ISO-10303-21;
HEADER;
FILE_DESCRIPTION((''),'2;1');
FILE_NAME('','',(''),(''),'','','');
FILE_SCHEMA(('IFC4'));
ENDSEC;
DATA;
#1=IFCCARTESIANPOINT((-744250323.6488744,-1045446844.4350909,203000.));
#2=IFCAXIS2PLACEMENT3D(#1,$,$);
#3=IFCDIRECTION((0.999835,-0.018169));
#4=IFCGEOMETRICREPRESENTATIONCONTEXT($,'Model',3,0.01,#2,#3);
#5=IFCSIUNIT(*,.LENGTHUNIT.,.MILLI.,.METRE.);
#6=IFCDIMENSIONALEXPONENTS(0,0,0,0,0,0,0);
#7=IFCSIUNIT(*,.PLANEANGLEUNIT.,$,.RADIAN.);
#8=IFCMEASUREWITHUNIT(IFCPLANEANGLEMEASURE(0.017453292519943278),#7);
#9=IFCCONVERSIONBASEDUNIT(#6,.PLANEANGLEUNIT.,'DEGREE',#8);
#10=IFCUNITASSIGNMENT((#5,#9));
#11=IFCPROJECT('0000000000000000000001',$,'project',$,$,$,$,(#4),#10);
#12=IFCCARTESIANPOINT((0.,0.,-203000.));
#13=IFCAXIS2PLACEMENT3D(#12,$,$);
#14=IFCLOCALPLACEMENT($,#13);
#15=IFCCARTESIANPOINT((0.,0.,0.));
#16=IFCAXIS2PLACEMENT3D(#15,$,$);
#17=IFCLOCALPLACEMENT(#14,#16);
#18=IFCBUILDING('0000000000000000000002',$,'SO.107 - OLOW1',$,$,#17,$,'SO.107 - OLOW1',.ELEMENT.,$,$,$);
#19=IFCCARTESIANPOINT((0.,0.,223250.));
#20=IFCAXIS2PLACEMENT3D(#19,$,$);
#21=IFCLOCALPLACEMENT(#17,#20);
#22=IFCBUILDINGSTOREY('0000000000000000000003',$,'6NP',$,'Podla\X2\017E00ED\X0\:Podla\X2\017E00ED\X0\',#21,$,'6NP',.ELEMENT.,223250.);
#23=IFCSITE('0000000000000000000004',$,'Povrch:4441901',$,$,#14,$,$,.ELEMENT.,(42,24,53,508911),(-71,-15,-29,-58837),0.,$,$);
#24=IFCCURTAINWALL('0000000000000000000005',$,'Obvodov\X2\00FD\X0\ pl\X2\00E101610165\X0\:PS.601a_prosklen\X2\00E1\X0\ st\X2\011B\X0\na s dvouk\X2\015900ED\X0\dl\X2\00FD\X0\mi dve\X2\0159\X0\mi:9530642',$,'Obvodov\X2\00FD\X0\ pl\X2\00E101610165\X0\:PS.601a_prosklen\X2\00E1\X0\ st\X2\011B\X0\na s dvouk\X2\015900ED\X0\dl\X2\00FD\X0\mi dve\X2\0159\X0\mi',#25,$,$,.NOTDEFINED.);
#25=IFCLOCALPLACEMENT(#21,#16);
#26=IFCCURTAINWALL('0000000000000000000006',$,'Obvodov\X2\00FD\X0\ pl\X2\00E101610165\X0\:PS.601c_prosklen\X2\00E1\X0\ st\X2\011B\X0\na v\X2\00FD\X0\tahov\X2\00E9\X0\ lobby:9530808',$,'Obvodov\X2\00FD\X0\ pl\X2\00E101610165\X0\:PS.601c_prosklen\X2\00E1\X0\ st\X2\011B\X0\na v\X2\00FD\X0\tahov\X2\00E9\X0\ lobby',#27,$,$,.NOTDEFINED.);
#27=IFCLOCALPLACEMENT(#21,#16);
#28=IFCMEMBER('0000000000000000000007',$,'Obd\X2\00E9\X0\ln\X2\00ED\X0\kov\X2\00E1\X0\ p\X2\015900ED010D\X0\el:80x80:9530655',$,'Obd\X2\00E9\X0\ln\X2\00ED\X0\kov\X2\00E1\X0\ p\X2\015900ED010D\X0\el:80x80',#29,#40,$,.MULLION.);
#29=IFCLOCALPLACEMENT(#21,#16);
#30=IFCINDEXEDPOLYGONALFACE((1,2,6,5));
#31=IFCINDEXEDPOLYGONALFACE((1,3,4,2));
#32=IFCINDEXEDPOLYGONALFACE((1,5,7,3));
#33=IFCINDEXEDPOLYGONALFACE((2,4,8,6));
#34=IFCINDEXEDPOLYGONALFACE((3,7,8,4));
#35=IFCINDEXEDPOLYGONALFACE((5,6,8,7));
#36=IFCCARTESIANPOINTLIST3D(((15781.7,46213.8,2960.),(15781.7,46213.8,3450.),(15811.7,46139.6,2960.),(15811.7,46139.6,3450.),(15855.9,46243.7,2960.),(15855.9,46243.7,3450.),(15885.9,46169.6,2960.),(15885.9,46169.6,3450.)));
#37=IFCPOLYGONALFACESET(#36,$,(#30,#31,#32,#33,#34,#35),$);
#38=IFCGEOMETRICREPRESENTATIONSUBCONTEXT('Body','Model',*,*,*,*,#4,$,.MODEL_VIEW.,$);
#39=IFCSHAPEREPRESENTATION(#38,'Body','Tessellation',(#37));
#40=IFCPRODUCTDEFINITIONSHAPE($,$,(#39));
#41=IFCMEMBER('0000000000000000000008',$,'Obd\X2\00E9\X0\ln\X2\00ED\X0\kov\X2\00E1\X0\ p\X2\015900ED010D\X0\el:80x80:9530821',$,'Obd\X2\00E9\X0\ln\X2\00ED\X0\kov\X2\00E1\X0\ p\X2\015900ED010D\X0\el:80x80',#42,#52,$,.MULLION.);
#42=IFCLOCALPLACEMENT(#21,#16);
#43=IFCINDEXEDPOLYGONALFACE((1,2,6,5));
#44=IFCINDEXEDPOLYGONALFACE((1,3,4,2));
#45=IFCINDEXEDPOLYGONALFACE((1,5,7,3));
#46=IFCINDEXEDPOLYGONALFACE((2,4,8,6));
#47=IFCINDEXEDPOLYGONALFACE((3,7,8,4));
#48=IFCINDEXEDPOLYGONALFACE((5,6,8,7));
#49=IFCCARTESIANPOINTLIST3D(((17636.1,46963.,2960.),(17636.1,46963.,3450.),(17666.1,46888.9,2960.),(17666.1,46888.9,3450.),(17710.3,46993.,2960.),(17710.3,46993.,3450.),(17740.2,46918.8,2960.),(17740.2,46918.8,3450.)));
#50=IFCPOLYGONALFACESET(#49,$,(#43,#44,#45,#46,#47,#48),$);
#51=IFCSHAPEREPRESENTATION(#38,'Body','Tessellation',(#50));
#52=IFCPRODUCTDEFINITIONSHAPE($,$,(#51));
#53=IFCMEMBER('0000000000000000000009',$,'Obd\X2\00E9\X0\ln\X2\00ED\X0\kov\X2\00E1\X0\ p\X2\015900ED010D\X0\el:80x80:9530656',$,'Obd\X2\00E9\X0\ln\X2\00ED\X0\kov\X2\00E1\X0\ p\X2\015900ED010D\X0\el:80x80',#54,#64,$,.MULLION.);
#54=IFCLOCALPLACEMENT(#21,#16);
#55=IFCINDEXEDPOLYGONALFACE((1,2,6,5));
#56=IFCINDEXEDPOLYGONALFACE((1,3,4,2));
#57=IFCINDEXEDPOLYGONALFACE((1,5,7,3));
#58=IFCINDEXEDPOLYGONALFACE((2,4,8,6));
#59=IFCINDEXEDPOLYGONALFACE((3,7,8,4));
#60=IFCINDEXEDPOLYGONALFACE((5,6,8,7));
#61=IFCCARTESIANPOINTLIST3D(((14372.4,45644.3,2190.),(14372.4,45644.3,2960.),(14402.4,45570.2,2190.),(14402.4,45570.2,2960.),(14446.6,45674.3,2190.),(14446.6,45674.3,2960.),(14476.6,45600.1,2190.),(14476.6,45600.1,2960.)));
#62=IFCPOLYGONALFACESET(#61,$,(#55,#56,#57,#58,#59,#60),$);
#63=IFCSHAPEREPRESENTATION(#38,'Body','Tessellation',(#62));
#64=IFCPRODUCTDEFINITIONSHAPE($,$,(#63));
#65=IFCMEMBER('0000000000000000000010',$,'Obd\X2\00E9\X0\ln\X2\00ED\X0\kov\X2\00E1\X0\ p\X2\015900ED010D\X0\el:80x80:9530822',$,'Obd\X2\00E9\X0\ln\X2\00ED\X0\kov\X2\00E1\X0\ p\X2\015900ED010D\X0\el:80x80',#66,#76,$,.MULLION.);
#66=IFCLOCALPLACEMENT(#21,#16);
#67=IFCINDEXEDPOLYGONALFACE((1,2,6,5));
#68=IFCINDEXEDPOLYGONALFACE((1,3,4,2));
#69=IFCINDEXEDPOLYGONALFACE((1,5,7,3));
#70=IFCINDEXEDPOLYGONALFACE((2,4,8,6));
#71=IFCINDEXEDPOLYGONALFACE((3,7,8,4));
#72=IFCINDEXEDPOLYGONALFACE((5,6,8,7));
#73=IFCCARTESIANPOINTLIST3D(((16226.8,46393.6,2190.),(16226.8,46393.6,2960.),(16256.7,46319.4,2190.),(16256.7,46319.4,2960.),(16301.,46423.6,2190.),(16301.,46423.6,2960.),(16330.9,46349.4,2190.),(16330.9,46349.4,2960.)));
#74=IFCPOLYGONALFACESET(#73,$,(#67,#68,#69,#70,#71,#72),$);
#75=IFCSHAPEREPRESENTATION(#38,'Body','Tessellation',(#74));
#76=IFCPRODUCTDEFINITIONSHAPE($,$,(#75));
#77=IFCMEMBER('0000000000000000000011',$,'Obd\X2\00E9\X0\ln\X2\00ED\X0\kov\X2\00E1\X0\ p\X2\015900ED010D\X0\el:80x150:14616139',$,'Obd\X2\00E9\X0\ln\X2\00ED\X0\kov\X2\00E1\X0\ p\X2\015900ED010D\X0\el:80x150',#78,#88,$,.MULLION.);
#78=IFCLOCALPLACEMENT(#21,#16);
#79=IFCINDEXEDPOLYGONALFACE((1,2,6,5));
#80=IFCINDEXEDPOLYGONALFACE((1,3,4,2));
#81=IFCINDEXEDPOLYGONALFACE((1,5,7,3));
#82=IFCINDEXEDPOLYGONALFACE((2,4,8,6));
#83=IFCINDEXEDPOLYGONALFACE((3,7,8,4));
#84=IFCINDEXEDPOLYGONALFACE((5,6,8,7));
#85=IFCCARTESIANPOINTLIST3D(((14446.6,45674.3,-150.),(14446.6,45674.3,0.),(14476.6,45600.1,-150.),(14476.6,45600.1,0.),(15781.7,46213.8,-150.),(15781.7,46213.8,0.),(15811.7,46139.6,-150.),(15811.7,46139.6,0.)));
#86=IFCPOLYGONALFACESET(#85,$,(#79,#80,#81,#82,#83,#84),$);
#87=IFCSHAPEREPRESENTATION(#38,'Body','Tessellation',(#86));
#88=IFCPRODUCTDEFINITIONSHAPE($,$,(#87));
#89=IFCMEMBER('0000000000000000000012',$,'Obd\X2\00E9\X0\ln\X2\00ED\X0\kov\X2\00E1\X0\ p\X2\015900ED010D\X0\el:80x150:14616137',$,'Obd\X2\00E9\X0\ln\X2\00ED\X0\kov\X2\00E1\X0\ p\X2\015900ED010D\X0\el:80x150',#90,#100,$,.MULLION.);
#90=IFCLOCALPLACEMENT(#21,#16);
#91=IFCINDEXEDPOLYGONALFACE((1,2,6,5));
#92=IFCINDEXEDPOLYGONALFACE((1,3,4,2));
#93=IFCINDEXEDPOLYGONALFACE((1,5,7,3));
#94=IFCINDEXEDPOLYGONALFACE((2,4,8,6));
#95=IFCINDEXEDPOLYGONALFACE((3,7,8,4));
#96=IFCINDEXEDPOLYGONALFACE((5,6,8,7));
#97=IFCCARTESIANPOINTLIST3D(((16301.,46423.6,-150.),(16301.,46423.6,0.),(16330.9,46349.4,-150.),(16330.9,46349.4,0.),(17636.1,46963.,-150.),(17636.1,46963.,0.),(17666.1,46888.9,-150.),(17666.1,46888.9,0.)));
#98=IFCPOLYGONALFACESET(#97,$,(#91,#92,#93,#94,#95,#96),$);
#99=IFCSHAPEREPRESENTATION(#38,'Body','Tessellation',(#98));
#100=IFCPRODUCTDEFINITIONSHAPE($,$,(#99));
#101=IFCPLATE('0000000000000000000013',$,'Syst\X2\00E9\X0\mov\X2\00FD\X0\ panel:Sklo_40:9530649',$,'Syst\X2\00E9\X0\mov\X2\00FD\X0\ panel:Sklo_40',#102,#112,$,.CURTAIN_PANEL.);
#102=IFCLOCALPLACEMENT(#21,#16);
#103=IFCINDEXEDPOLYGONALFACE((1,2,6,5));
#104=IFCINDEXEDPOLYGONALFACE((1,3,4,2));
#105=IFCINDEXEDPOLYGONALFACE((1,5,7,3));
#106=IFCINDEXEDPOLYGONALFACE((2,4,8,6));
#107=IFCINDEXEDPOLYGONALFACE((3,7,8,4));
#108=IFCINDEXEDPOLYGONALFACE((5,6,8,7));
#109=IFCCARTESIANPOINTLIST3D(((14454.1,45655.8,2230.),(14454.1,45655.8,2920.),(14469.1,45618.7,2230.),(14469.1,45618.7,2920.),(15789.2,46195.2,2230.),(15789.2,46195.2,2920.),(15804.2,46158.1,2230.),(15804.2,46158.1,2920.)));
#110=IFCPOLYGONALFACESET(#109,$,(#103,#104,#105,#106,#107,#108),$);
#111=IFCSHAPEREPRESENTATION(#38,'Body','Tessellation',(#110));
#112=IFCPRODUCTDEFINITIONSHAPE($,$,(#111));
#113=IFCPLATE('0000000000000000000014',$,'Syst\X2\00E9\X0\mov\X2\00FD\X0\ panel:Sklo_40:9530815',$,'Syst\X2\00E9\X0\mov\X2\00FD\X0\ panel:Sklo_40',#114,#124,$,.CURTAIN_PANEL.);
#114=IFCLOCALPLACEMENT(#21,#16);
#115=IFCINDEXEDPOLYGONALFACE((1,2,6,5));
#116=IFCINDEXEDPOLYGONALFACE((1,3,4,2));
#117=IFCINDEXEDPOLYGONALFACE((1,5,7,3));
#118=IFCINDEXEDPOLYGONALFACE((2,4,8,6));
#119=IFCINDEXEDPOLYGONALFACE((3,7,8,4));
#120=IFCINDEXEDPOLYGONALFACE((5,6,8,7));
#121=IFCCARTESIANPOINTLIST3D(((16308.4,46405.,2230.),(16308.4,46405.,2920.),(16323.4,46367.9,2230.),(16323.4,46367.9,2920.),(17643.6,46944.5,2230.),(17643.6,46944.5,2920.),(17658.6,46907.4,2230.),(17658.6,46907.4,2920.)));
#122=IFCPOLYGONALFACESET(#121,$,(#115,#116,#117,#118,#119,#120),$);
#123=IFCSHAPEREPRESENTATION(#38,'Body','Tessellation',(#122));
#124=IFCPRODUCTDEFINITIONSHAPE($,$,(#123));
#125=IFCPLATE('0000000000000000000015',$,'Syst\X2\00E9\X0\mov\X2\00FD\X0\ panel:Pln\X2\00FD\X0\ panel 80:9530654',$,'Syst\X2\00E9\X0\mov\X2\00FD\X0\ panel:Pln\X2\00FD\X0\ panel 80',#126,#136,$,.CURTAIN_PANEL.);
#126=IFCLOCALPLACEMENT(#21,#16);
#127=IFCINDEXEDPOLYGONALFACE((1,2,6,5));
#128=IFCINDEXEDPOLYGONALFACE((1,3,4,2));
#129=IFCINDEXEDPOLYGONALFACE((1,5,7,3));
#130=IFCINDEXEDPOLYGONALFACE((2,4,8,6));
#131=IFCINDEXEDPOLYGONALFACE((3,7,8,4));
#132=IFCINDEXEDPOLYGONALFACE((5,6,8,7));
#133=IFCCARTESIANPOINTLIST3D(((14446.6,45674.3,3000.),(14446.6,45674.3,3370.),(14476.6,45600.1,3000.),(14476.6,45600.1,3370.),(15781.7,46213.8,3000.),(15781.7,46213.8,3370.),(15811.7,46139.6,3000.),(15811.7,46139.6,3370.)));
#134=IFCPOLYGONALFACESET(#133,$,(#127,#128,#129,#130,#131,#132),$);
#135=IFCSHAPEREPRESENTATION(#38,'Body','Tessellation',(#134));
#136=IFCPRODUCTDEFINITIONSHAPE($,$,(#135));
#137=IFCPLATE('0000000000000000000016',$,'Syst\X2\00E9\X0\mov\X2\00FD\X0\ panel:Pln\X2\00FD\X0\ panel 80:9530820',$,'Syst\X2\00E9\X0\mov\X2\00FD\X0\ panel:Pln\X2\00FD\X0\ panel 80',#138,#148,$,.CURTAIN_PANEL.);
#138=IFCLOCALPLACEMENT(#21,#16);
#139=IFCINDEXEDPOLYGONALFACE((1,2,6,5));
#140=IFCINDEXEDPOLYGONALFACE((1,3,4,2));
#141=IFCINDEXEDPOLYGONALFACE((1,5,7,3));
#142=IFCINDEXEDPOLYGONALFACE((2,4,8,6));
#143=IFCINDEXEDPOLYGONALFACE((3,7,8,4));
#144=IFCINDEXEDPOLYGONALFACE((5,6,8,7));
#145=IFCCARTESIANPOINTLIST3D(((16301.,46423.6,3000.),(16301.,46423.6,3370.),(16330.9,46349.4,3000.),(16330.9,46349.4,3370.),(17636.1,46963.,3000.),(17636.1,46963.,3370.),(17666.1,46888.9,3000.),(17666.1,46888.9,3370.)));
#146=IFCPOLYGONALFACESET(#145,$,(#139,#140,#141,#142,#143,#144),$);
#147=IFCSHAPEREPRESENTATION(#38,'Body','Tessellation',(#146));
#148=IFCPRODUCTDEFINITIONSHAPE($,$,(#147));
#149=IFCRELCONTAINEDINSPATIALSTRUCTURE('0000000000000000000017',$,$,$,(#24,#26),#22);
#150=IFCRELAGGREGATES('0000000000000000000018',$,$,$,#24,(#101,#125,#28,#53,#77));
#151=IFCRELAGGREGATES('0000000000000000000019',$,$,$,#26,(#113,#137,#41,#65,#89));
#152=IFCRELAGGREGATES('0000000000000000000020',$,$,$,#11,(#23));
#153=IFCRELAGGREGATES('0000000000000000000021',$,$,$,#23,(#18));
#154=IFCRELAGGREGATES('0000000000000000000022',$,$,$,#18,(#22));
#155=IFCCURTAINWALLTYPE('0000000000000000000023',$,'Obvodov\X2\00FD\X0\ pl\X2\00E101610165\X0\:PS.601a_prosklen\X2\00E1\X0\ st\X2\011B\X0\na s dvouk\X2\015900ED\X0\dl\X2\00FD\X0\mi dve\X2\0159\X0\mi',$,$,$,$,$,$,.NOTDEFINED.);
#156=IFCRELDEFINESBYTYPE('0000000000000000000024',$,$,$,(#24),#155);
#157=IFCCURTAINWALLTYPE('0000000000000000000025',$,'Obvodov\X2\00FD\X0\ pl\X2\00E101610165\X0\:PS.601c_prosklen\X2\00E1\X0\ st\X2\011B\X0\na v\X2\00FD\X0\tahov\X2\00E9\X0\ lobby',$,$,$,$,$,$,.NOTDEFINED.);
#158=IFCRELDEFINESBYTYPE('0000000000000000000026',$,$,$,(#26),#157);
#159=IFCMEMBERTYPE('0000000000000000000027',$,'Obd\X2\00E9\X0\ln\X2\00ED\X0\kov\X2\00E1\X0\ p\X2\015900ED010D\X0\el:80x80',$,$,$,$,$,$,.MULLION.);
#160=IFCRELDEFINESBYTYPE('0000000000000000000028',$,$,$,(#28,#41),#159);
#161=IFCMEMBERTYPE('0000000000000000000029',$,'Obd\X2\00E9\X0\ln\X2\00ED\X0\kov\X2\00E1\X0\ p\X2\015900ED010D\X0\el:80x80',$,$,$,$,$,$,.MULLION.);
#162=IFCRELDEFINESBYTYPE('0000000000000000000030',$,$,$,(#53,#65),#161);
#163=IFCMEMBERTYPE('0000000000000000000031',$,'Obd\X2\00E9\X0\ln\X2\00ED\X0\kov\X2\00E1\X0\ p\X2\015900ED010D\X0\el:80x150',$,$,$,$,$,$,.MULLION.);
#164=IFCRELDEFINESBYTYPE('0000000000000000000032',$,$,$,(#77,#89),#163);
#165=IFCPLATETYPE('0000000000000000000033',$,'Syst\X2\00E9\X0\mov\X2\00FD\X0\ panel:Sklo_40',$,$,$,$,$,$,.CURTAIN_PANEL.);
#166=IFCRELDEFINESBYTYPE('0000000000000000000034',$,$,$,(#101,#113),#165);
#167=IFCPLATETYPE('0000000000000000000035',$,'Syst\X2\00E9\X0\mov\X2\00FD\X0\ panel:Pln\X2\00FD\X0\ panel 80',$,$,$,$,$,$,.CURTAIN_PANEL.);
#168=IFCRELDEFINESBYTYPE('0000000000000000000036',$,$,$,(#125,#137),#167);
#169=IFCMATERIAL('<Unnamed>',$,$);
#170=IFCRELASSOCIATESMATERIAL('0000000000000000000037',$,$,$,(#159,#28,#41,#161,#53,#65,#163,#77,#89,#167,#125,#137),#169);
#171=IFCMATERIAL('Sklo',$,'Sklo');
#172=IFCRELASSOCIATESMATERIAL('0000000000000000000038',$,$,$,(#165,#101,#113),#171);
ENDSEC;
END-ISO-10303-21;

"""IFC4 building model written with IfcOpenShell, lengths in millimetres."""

from ifc_helpers import new_model, entity, si_unit, converted_unit, direction, frame, origin, place, context, subcontext, project, spatial, indexed_curve, outline, extrude, source, transform, mapped, material, type_object, type_shapes, element, aggregate, save


model = new_model("IFC4")

# Units and contexts
model_context = context("Model", 3, precision=0.01, world=frame((-744250323.6488744, -1045446844.4350909, 203000.0)), true_north=direction((0.999835, -0.018169)))
body_context = subcontext(model_context, "Body", "Model", "MODEL_VIEW")
ifc_project = project(units=[si_unit("LENGTHUNIT", "METRE", prefix="MILLI"), converted_unit("PLANEANGLEUNIT", "DEGREE", entity("IfcPlaneAngleMeasure", 0.017453292519943278), si_unit("PLANEANGLEUNIT", "RADIAN"), dimensions=[0, 0, 0, 0, 0, 0, 0])], contexts=[model_context])

# Site, building, storey
site_placement = place(None, frame((0.0, 0.0, -203000.0)))
site = spatial("IfcSite", under=ifc_project, at=site_placement, Name="Povrch:4441901", CompositionType="ELEMENT", RefLatitude=(42, 24, 53, 508911), RefLongitude=(-71, -15, -29, -58837), RefElevation=0.0)
building_placement = place(site_placement, origin())
building = spatial("IfcBuilding", under=site, at=building_placement, Name="SO.107 - OLOW1", LongName="SO.107 - OLOW1", CompositionType="ELEMENT")
storey_placement = place(building_placement, frame((0.0, 0.0, 223250.0)))
storey = spatial("IfcBuildingStorey", under=building, at=storey_placement, Name="6NP", ObjectType="Podlaží:Podlaží", LongName="6NP", CompositionType="ELEMENT", Elevation=223250.0)

# Curtain walls
curtain_wall_type_1 = type_object("IfcCurtainWallType", Name="Obvodový plášť:PS.601a_prosklená stěna s dvoukřídlými dveřmi", PredefinedType="NOTDEFINED")
curtain_wall_1_placement = place(storey_placement, frame((0.0, 0.0, -223250.0)))
curtain_wall_1 = element("IfcCurtainWall", 1, at=curtain_wall_1_placement, inside=storey, type_object=curtain_wall_type_1, Name="Obvodový plášť:PS.601a_prosklená stěna s dvoukřídlými dveřmi:9530642", ObjectType="Obvodový plášť:PS.601a_prosklená stěna s dvoukřídlými dveřmi", PredefinedType="NOTDEFINED")
ifc_material_1 = material(Name="<Unnamed>")
curtain_wall_type_2 = type_object("IfcCurtainWallType", Name="Obvodový plášť:PS.601c_prosklená stěna výtahové lobby", PredefinedType="NOTDEFINED")
curtain_wall_2_placement = place(storey_placement, frame((0.0, 0.0, -223250.0)))
curtain_wall_2 = element("IfcCurtainWall", 2, at=curtain_wall_2_placement, inside=storey, type_object=curtain_wall_type_2, Name="Obvodový plášť:PS.601c_prosklená stěna výtahové lobby:9530808", ObjectType="Obvodový plášť:PS.601c_prosklená stěna výtahové lobby", PredefinedType="NOTDEFINED")

# Members
member_type_1 = type_object("IfcMemberType", Name="Obdélníková příčel:80x80", PredefinedType="MULLION", material=ifc_material_1)
shared_shape_1 = source(origin(), body_context, "Body", "SweptSolid", [
    extrude(outline(indexed_curve([(-40.0, -40.0), (40.0, -40.0), (40.0, 40.0), (-40.0, 40.0), (-40.0, -40.0)], self_intersect=False)), frame((-40.0, 0.0, -490.0), z_axis=(0.0, 0.0, 1.0), x_axis=(-1.0, 0.0, 0.0)), (0.0, 0.0, 1.0), 490.0),
])
type_shapes(member_type_1, [shared_shape_1])
member_1_placement = place(curtain_wall_1_placement, frame((15870.9, 46206.7, 226210.0), z_axis=(0.0, 0.0, -1.0), x_axis=(0.927176, 0.374626, 0.0)))
member_1 = element("IfcMember", 3, at=member_1_placement, type_object=member_type_1, material=ifc_material_1, Name="Obdélníková příčel:80x80:9530655", ObjectType="Obdélníková příčel:80x80", PredefinedType="MULLION", context=body_context, shape_type="MappedRepresentation", body=[
    mapped(shared_shape_1, transform((0.0, 0.0, 0.0), scale=1.0)),
])
member_2_placement = place(curtain_wall_2_placement, frame((17725.2, 46955.9, 226210.0), z_axis=(0.0, 0.0, -1.0), x_axis=(0.927176, 0.374626, 0.0)))
member_2 = element("IfcMember", 4, at=member_2_placement, type_object=member_type_1, material=ifc_material_1, Name="Obdélníková příčel:80x80:9530821", ObjectType="Obdélníková příčel:80x80", PredefinedType="MULLION", context=body_context, shape_type="MappedRepresentation", body=[
    mapped(shared_shape_1, transform((0.0, 0.0, 0.0), scale=1.0)),
])
member_type_2 = type_object("IfcMemberType", Name="Obdélníková příčel:80x80", PredefinedType="MULLION", material=ifc_material_1)
shared_shape_2 = source(origin(), body_context, "Body", "SweptSolid", [
    extrude(outline(indexed_curve([(-40.0, -40.0), (40.0, -40.0), (40.0, 40.0), (-40.0, 40.0), (-40.0, -40.0)], self_intersect=False)), frame((-40.0, 0.0, -770.0), z_axis=(0.0, 0.0, 1.0), x_axis=(-1.0, 0.0, 0.0)), (0.0, 0.0, 1.0), 770.0),
])
type_shapes(member_type_2, [shared_shape_2])
member_3_placement = place(curtain_wall_1_placement, frame((14387.4, 45607.3, 226210.0), z_axis=(0.0, 0.0, 1.0), x_axis=(-0.927176, -0.374626, 0.0)))
member_3 = element("IfcMember", 5, at=member_3_placement, type_object=member_type_2, material=ifc_material_1, Name="Obdélníková příčel:80x80:9530656", ObjectType="Obdélníková příčel:80x80", PredefinedType="MULLION", context=body_context, shape_type="MappedRepresentation", body=[
    mapped(shared_shape_2, transform((0.0, 0.0, 0.0), scale=1.0)),
])
member_4_placement = place(curtain_wall_2_placement, frame((16241.8, 46356.5, 226210.0), z_axis=(0.0, 0.0, 1.0), x_axis=(-0.927176, -0.374626, 0.0)))
member_4 = element("IfcMember", 6, at=member_4_placement, type_object=member_type_2, material=ifc_material_1, Name="Obdélníková příčel:80x80:9530822", ObjectType="Obdélníková příčel:80x80", PredefinedType="MULLION", context=body_context, shape_type="MappedRepresentation", body=[
    mapped(shared_shape_2, transform((0.0, 0.0, 0.0), scale=1.0)),
])
member_type_3 = type_object("IfcMemberType", Name="Obdélníková příčel:80x150", PredefinedType="MULLION", material=ifc_material_1)
shared_shape_3 = source(origin(), body_context, "Body", "SweptSolid", [
    extrude(outline(indexed_curve([(-75.0, -40.0), (75.0, -40.0), (75.0, 40.0), (-75.0, 40.0), (-75.0, -40.0)], self_intersect=False)), frame((-75.0, 0.0, -1440.0), z_axis=(0.0, 0.0, 1.0), x_axis=(-1.0, 0.0, 0.0)), (0.0, 0.0, 1.0), 1440.0),
])
type_shapes(member_type_3, [shared_shape_3])
member_5_placement = place(curtain_wall_1_placement, frame((14461.6, 45637.2, 223100.0), z_axis=(-0.927176, -0.374626, 0.0), x_axis=(0.0, 0.0, -1.0)))
member_5 = element("IfcMember", 7, at=member_5_placement, type_object=member_type_3, material=ifc_material_1, Name="Obdélníková příčel:80x150:14616139", ObjectType="Obdélníková příčel:80x150", PredefinedType="MULLION", context=body_context, shape_type="MappedRepresentation", body=[
    mapped(shared_shape_3, transform((0.0, 0.0, 0.0), scale=1.0)),
])
member_6_placement = place(curtain_wall_2_placement, frame((16315.9, 46386.5, 223100.0), z_axis=(-0.927176, -0.374626, 0.0), x_axis=(0.0, 0.0, -1.0)))
member_6 = element("IfcMember", 8, at=member_6_placement, type_object=member_type_3, material=ifc_material_1, Name="Obdélníková příčel:80x150:14616137", ObjectType="Obdélníková příčel:80x150", PredefinedType="MULLION", context=body_context, shape_type="MappedRepresentation", body=[
    mapped(shared_shape_3, transform((0.0, 0.0, 0.0), scale=1.0)),
])

# Plates
ifc_material_2 = material(Name="Sklo", Category="Sklo")
plate_type_1 = type_object("IfcPlateType", Name="Systémový panel:Sklo_40", PredefinedType="CURTAIN_PANEL", material=ifc_material_2)
shared_shape_4 = source(origin(), body_context, "Body", "SweptSolid", [
    extrude(outline(indexed_curve([(-20.0, -720.0), (20.0, -720.0), (20.0, 720.0), (-20.0, 720.0), (-20.0, -720.0)], self_intersect=False)), frame((0.0, 0.0, 0.0), z_axis=(0.0, 0.0, 1.0), x_axis=(0.0, 1.0, 0.0)), (0.0, 0.0, 1.0), 690.0),
])
type_shapes(plate_type_1, [shared_shape_4])
plate_1_placement = place(curtain_wall_1_placement, frame((15129.2, 45907.0, 225480.0), z_axis=(0.0, 0.0, 1.0), x_axis=(0.927176, 0.374626, 0.0)))
plate_1 = element("IfcPlate", 9, at=plate_1_placement, type_object=plate_type_1, material=ifc_material_2, Name="Systémový panel:Sklo_40:9530649", ObjectType="Systémový panel:Sklo_40", PredefinedType="CURTAIN_PANEL", context=body_context, shape_type="MappedRepresentation", body=[
    mapped(shared_shape_4, transform((0.0, 0.0, 0.0), scale=1.0)),
])
plate_2_placement = place(curtain_wall_2_placement, frame((16983.5, 46656.2, 225480.0), z_axis=(0.0, 0.0, 1.0), x_axis=(0.927176, 0.374626, 0.0)))
plate_2 = element("IfcPlate", 10, at=plate_2_placement, type_object=plate_type_1, material=ifc_material_2, Name="Systémový panel:Sklo_40:9530815", ObjectType="Systémový panel:Sklo_40", PredefinedType="CURTAIN_PANEL", context=body_context, shape_type="MappedRepresentation", body=[
    mapped(shared_shape_4, transform((0.0, 0.0, 0.0), scale=1.0)),
])
plate_type_2 = type_object("IfcPlateType", Name="Systémový panel:Plný panel 80", PredefinedType="CURTAIN_PANEL", material=ifc_material_1)
shared_shape_5 = source(origin(), body_context, "Body", "SweptSolid", [
    extrude(outline(indexed_curve([(-40.0, -720.0), (40.0, -720.0), (40.0, 720.0), (-40.0, 720.0), (-40.0, -720.0)], self_intersect=False)), frame((0.0, 0.0, 0.0), z_axis=(0.0, 0.0, 1.0), x_axis=(0.0, 1.0, 0.0)), (0.0, 0.0, 1.0), 370.0),
])
type_shapes(plate_type_2, [shared_shape_5])
plate_3_placement = place(curtain_wall_1_placement, frame((15129.2, 45907.0, 226250.0), z_axis=(0.0, 0.0, 1.0), x_axis=(0.927176, 0.374626, 0.0)))
plate_3 = element("IfcPlate", 11, at=plate_3_placement, type_object=plate_type_2, material=ifc_material_1, Name="Systémový panel:Plný panel 80:9530654", ObjectType="Systémový panel:Plný panel 80", PredefinedType="CURTAIN_PANEL", context=body_context, shape_type="MappedRepresentation", body=[
    mapped(shared_shape_5, transform((0.0, 0.0, 0.0), scale=1.0)),
])
plate_4_placement = place(curtain_wall_2_placement, frame((16983.5, 46656.2, 226250.0), z_axis=(0.0, 0.0, 1.0), x_axis=(0.927176, 0.374626, 0.0)))
plate_4 = element("IfcPlate", 12, at=plate_4_placement, type_object=plate_type_2, material=ifc_material_1, Name="Systémový panel:Plný panel 80:9530820", ObjectType="Systémový panel:Plný panel 80", PredefinedType="CURTAIN_PANEL", context=body_context, shape_type="MappedRepresentation", body=[
    mapped(shared_shape_5, transform((0.0, 0.0, 0.0), scale=1.0)),
])

aggregate(curtain_wall_1, [plate_1, plate_3, member_1, member_3, member_5])
aggregate(curtain_wall_2, [plate_2, plate_4, member_2, member_4, member_6])

save(model, "model.ifc")
